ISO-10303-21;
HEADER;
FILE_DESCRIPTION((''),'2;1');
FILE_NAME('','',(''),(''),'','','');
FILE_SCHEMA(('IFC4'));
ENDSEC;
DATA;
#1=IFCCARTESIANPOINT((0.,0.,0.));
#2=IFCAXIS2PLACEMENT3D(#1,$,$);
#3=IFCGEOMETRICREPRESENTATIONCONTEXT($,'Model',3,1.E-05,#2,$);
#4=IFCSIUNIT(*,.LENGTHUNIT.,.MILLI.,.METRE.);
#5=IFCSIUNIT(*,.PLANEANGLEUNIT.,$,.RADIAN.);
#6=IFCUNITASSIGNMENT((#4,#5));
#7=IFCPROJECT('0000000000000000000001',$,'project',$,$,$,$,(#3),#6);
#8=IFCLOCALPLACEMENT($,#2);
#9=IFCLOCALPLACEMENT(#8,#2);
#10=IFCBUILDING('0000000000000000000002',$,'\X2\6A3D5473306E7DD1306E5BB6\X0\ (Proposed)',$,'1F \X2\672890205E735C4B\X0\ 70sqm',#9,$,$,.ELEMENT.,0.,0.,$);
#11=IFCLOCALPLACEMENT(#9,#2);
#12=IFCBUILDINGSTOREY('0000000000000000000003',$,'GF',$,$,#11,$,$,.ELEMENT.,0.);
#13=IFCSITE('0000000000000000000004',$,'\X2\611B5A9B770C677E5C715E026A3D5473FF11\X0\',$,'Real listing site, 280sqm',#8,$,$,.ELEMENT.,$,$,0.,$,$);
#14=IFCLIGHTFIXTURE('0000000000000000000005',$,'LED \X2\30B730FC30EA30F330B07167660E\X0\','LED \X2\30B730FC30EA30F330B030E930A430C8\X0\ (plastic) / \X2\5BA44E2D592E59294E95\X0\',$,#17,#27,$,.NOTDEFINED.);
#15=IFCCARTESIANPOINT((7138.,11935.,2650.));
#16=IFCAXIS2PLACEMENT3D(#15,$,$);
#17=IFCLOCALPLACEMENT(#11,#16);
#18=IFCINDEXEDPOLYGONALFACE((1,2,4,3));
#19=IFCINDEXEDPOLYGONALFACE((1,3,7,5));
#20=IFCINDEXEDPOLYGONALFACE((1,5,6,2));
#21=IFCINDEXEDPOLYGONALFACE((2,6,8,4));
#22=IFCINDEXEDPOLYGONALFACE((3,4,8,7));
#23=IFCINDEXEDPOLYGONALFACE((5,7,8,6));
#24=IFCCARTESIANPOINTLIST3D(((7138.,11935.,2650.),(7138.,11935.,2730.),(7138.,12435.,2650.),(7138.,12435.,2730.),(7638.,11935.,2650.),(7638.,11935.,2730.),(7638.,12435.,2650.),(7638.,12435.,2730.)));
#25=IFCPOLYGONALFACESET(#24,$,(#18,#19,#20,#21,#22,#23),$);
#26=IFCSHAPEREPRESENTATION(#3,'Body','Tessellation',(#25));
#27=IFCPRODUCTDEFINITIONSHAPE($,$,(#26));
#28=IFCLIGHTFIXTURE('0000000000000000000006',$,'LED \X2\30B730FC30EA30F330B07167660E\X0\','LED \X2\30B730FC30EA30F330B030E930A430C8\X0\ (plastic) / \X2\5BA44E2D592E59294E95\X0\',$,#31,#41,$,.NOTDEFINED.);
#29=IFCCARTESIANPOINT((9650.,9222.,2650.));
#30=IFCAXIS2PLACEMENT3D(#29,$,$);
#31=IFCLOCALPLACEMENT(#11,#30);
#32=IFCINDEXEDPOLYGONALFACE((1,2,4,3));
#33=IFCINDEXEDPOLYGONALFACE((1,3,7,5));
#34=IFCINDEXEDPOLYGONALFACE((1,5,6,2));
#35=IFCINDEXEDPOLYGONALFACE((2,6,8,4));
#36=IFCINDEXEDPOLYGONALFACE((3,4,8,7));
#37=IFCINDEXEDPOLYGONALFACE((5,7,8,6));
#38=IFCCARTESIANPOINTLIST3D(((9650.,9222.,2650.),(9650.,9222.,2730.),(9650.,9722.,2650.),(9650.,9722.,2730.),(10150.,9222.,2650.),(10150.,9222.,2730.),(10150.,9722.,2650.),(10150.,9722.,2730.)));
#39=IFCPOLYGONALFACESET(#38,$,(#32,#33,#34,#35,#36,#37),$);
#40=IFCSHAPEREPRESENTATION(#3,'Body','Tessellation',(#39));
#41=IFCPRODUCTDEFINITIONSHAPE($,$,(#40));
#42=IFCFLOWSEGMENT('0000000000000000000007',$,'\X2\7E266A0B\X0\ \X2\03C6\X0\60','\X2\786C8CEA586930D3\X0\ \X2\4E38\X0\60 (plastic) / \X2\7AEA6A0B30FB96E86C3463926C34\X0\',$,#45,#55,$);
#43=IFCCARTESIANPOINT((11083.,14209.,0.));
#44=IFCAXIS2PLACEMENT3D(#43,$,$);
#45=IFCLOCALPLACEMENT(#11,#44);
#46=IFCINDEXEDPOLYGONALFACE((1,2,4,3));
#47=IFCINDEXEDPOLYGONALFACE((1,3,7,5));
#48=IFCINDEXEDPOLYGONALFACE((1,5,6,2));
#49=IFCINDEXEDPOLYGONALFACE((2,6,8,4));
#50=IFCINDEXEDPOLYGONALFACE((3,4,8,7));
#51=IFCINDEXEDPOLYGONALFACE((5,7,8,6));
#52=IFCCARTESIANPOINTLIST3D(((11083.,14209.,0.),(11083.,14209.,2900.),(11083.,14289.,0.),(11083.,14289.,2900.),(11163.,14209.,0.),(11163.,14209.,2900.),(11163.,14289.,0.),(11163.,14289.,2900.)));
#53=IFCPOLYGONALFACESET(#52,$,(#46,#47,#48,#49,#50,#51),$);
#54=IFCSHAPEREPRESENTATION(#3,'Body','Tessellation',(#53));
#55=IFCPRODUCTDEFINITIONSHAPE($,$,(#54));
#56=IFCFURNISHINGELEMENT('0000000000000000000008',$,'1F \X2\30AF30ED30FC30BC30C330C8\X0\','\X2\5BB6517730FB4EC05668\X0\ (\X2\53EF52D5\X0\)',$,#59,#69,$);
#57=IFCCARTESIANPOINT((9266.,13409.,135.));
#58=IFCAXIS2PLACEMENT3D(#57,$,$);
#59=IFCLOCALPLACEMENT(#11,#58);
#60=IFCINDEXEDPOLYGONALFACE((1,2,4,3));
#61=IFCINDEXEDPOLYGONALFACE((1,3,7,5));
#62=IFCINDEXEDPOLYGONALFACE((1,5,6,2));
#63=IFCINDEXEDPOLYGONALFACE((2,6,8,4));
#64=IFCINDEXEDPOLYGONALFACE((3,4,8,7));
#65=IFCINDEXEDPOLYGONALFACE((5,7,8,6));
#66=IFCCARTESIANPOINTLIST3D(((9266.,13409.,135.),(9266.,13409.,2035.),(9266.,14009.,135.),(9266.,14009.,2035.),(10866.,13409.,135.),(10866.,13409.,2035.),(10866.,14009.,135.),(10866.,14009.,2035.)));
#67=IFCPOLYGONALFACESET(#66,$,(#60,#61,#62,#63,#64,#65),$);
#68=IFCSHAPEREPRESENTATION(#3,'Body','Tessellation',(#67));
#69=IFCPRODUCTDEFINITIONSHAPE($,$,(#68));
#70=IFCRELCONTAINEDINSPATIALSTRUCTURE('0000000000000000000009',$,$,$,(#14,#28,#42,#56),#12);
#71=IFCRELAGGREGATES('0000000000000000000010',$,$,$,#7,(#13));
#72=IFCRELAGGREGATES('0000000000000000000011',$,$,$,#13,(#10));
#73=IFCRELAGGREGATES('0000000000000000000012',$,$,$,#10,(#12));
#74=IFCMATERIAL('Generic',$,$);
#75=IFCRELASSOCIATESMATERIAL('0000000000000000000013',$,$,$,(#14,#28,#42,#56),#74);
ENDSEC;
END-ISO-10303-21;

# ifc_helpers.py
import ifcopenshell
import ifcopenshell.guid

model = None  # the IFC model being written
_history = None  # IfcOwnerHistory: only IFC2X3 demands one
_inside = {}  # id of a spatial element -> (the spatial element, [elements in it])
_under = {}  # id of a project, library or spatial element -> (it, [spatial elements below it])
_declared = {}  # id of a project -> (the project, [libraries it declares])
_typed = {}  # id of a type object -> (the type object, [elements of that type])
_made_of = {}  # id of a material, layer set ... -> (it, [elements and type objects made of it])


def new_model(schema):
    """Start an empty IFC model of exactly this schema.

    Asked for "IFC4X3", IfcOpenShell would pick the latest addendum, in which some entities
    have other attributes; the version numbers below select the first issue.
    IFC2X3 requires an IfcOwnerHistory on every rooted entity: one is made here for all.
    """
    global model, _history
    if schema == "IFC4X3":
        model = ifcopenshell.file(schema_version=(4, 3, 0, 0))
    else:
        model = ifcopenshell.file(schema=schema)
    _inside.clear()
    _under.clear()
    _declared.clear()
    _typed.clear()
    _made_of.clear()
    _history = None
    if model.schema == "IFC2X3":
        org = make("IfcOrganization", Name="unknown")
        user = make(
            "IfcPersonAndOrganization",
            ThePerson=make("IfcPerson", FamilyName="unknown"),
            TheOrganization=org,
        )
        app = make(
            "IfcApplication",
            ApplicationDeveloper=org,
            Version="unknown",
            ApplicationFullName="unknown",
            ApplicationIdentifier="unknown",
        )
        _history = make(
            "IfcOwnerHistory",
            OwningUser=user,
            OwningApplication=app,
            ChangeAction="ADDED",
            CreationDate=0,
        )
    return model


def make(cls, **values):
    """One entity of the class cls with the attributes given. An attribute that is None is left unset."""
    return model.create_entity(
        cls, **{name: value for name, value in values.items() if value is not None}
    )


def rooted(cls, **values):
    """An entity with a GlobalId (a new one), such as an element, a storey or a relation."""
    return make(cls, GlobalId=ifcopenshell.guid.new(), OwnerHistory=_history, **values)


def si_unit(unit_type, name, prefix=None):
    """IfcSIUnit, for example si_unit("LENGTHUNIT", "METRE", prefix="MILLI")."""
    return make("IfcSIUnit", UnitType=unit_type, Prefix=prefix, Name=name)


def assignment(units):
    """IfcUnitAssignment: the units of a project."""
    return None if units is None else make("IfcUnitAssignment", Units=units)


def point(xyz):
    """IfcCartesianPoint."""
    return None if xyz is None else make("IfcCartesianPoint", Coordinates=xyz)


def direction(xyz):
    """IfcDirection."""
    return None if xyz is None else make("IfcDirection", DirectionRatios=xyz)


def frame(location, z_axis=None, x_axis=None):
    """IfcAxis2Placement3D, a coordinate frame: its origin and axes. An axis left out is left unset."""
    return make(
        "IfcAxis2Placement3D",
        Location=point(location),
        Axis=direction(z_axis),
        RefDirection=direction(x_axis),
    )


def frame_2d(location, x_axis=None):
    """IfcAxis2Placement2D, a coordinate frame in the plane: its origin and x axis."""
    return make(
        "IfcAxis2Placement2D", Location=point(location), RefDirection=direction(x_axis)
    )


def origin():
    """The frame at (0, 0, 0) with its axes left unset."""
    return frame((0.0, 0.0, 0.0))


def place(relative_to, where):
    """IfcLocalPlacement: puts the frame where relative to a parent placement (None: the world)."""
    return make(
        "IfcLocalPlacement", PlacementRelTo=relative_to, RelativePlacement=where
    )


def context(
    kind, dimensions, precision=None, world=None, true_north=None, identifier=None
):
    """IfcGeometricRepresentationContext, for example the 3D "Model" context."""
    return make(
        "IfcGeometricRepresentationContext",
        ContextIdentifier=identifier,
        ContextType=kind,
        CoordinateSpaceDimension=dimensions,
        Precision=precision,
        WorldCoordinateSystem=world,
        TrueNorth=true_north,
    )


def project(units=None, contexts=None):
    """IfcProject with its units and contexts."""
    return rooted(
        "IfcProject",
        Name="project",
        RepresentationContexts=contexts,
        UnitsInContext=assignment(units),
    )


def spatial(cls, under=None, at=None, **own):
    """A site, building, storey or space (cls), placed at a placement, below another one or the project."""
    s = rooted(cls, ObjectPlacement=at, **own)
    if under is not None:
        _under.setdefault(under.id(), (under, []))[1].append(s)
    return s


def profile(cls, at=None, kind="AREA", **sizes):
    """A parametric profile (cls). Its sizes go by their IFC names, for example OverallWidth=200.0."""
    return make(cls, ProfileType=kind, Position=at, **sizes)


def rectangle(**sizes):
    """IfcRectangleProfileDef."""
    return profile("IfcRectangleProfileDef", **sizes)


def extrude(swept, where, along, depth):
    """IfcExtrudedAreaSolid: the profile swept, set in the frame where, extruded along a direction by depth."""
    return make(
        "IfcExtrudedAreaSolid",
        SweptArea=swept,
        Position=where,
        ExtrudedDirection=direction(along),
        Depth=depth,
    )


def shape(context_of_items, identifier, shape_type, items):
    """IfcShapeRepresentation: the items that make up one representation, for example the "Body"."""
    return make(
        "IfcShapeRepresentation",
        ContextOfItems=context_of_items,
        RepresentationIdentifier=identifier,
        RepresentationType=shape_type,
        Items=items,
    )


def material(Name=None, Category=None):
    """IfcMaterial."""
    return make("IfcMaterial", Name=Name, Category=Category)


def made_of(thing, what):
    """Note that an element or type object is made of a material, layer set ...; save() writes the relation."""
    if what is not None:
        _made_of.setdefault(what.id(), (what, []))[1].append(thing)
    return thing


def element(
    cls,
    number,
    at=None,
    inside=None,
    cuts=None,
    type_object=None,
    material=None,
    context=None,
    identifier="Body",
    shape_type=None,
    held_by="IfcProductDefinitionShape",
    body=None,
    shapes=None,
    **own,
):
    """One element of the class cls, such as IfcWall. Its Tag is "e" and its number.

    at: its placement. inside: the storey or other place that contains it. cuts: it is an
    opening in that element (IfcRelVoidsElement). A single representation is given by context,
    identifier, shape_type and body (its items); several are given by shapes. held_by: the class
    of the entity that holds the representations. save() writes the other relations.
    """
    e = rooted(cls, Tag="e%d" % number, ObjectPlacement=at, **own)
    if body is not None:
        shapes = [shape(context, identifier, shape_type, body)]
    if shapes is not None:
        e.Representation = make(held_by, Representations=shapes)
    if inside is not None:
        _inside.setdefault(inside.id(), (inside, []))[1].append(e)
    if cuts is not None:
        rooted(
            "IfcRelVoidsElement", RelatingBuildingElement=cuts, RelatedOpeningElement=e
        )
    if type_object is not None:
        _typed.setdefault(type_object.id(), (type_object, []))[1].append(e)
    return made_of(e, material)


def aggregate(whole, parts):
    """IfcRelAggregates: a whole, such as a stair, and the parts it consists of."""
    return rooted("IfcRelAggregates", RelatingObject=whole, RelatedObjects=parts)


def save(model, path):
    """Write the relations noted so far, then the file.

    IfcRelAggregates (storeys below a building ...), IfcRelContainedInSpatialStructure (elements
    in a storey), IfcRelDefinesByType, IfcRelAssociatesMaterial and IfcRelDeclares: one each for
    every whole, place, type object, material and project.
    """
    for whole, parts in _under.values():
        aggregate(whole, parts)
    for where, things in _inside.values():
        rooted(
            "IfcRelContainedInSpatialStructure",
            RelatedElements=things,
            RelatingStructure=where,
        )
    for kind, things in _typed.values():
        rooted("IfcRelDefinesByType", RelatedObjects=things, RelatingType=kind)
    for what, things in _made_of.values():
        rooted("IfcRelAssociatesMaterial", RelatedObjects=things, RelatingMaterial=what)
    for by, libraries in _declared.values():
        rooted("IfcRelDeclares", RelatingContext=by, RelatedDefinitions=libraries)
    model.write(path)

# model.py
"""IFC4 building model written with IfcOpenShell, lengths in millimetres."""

from ifc_helpers import new_model, si_unit, frame, frame_2d, origin, place, context, project, spatial, rectangle, extrude, material, element, save


model = new_model("IFC4")

# Units and contexts
model_context = context("Model", 3, precision=1e-05, world=origin())
ifc_project = project(units=[si_unit("LENGTHUNIT", "METRE", prefix="MILLI"), si_unit("PLANEANGLEUNIT", "RADIAN")], contexts=[model_context])

# Site, building, storey
site_placement = place(None, origin())
site = spatial("IfcSite", under=ifc_project, at=site_placement, Name="愛媛県松山市樽味１", ObjectType="Real listing site, 280sqm", CompositionType="ELEMENT", RefElevation=0.0)
building_placement = place(site_placement, origin())
building = spatial("IfcBuilding", under=site, at=building_placement, Name="樽味の緑の家 (Proposed)", ObjectType="1F 木造平屋 70sqm", CompositionType="ELEMENT", ElevationOfRefHeight=0.0, ElevationOfTerrain=0.0)
storey_placement = place(building_placement, origin())
storey = spatial("IfcBuildingStorey", under=building, at=storey_placement, Name="GF", CompositionType="ELEMENT", Elevation=0.0)

# Shared definitions
ifc_material_1 = material(Name="Generic")

# Light fixtures
light_fixture_1_placement = place(storey_placement, frame((7138.0, 11935.0, 2650.0)))
element("IfcLightFixture", 1, at=light_fixture_1_placement, inside=storey, material=ifc_material_1, Name="LED シーリング照明", Description="LED シーリングライト (plastic) / 室中央天井", PredefinedType="NOTDEFINED", context=model_context, shape_type="SweptSolid", body=[
    extrude(rectangle(XDim=500.0, YDim=500.0, at=frame_2d((250.0, 250.0))), frame((7138.0, 11935.0, 2650.0)), (0.0, 0.0, 1.0), 80.0),
])
light_fixture_2_placement = place(storey_placement, frame((9650.0, 9222.0, 2650.0)))
element("IfcLightFixture", 2, at=light_fixture_2_placement, inside=storey, material=ifc_material_1, Name="LED シーリング照明", Description="LED シーリングライト (plastic) / 室中央天井", PredefinedType="NOTDEFINED", context=model_context, shape_type="SweptSolid", body=[
    extrude(rectangle(XDim=500.0, YDim=500.0, at=frame_2d((250.0, 250.0))), frame((9650.0, 9222.0, 2650.0)), (0.0, 0.0, 1.0), 80.0),
])

# Flow segment
flow_segment_placement = place(storey_placement, frame((11083.0, 14209.0, 0.0)))
element("IfcFlowSegment", 3, at=flow_segment_placement, inside=storey, material=ifc_material_1, Name="縦樋 φ60", Description="硬質塩ビ 丸60 (plastic) / 竪樋・雨水排水", context=model_context, shape_type="SweptSolid", body=[
    extrude(rectangle(XDim=80.0, YDim=80.0, at=frame_2d((40.0, 40.0))), frame((11083.0, 14209.0, 0.0)), (0.0, 0.0, 1.0), 2900.0),
])

# Furnishing element
furnishing_placement = place(storey_placement, frame((9266.0, 13409.0, 135.0)))
element("IfcFurnishingElement", 4, at=furnishing_placement, inside=storey, material=ifc_material_1, Name="1F クローゼット", Description="家具・什器 (可動)", context=model_context, shape_type="SweptSolid", body=[
    extrude(rectangle(XDim=1600.0, YDim=600.0, at=frame_2d((800.0, 300.0))), frame((9266.0, 13409.0, 135.0)), (0.0, 0.0, 1.0), 1900.0),
])

save(model, "model.ifc")
